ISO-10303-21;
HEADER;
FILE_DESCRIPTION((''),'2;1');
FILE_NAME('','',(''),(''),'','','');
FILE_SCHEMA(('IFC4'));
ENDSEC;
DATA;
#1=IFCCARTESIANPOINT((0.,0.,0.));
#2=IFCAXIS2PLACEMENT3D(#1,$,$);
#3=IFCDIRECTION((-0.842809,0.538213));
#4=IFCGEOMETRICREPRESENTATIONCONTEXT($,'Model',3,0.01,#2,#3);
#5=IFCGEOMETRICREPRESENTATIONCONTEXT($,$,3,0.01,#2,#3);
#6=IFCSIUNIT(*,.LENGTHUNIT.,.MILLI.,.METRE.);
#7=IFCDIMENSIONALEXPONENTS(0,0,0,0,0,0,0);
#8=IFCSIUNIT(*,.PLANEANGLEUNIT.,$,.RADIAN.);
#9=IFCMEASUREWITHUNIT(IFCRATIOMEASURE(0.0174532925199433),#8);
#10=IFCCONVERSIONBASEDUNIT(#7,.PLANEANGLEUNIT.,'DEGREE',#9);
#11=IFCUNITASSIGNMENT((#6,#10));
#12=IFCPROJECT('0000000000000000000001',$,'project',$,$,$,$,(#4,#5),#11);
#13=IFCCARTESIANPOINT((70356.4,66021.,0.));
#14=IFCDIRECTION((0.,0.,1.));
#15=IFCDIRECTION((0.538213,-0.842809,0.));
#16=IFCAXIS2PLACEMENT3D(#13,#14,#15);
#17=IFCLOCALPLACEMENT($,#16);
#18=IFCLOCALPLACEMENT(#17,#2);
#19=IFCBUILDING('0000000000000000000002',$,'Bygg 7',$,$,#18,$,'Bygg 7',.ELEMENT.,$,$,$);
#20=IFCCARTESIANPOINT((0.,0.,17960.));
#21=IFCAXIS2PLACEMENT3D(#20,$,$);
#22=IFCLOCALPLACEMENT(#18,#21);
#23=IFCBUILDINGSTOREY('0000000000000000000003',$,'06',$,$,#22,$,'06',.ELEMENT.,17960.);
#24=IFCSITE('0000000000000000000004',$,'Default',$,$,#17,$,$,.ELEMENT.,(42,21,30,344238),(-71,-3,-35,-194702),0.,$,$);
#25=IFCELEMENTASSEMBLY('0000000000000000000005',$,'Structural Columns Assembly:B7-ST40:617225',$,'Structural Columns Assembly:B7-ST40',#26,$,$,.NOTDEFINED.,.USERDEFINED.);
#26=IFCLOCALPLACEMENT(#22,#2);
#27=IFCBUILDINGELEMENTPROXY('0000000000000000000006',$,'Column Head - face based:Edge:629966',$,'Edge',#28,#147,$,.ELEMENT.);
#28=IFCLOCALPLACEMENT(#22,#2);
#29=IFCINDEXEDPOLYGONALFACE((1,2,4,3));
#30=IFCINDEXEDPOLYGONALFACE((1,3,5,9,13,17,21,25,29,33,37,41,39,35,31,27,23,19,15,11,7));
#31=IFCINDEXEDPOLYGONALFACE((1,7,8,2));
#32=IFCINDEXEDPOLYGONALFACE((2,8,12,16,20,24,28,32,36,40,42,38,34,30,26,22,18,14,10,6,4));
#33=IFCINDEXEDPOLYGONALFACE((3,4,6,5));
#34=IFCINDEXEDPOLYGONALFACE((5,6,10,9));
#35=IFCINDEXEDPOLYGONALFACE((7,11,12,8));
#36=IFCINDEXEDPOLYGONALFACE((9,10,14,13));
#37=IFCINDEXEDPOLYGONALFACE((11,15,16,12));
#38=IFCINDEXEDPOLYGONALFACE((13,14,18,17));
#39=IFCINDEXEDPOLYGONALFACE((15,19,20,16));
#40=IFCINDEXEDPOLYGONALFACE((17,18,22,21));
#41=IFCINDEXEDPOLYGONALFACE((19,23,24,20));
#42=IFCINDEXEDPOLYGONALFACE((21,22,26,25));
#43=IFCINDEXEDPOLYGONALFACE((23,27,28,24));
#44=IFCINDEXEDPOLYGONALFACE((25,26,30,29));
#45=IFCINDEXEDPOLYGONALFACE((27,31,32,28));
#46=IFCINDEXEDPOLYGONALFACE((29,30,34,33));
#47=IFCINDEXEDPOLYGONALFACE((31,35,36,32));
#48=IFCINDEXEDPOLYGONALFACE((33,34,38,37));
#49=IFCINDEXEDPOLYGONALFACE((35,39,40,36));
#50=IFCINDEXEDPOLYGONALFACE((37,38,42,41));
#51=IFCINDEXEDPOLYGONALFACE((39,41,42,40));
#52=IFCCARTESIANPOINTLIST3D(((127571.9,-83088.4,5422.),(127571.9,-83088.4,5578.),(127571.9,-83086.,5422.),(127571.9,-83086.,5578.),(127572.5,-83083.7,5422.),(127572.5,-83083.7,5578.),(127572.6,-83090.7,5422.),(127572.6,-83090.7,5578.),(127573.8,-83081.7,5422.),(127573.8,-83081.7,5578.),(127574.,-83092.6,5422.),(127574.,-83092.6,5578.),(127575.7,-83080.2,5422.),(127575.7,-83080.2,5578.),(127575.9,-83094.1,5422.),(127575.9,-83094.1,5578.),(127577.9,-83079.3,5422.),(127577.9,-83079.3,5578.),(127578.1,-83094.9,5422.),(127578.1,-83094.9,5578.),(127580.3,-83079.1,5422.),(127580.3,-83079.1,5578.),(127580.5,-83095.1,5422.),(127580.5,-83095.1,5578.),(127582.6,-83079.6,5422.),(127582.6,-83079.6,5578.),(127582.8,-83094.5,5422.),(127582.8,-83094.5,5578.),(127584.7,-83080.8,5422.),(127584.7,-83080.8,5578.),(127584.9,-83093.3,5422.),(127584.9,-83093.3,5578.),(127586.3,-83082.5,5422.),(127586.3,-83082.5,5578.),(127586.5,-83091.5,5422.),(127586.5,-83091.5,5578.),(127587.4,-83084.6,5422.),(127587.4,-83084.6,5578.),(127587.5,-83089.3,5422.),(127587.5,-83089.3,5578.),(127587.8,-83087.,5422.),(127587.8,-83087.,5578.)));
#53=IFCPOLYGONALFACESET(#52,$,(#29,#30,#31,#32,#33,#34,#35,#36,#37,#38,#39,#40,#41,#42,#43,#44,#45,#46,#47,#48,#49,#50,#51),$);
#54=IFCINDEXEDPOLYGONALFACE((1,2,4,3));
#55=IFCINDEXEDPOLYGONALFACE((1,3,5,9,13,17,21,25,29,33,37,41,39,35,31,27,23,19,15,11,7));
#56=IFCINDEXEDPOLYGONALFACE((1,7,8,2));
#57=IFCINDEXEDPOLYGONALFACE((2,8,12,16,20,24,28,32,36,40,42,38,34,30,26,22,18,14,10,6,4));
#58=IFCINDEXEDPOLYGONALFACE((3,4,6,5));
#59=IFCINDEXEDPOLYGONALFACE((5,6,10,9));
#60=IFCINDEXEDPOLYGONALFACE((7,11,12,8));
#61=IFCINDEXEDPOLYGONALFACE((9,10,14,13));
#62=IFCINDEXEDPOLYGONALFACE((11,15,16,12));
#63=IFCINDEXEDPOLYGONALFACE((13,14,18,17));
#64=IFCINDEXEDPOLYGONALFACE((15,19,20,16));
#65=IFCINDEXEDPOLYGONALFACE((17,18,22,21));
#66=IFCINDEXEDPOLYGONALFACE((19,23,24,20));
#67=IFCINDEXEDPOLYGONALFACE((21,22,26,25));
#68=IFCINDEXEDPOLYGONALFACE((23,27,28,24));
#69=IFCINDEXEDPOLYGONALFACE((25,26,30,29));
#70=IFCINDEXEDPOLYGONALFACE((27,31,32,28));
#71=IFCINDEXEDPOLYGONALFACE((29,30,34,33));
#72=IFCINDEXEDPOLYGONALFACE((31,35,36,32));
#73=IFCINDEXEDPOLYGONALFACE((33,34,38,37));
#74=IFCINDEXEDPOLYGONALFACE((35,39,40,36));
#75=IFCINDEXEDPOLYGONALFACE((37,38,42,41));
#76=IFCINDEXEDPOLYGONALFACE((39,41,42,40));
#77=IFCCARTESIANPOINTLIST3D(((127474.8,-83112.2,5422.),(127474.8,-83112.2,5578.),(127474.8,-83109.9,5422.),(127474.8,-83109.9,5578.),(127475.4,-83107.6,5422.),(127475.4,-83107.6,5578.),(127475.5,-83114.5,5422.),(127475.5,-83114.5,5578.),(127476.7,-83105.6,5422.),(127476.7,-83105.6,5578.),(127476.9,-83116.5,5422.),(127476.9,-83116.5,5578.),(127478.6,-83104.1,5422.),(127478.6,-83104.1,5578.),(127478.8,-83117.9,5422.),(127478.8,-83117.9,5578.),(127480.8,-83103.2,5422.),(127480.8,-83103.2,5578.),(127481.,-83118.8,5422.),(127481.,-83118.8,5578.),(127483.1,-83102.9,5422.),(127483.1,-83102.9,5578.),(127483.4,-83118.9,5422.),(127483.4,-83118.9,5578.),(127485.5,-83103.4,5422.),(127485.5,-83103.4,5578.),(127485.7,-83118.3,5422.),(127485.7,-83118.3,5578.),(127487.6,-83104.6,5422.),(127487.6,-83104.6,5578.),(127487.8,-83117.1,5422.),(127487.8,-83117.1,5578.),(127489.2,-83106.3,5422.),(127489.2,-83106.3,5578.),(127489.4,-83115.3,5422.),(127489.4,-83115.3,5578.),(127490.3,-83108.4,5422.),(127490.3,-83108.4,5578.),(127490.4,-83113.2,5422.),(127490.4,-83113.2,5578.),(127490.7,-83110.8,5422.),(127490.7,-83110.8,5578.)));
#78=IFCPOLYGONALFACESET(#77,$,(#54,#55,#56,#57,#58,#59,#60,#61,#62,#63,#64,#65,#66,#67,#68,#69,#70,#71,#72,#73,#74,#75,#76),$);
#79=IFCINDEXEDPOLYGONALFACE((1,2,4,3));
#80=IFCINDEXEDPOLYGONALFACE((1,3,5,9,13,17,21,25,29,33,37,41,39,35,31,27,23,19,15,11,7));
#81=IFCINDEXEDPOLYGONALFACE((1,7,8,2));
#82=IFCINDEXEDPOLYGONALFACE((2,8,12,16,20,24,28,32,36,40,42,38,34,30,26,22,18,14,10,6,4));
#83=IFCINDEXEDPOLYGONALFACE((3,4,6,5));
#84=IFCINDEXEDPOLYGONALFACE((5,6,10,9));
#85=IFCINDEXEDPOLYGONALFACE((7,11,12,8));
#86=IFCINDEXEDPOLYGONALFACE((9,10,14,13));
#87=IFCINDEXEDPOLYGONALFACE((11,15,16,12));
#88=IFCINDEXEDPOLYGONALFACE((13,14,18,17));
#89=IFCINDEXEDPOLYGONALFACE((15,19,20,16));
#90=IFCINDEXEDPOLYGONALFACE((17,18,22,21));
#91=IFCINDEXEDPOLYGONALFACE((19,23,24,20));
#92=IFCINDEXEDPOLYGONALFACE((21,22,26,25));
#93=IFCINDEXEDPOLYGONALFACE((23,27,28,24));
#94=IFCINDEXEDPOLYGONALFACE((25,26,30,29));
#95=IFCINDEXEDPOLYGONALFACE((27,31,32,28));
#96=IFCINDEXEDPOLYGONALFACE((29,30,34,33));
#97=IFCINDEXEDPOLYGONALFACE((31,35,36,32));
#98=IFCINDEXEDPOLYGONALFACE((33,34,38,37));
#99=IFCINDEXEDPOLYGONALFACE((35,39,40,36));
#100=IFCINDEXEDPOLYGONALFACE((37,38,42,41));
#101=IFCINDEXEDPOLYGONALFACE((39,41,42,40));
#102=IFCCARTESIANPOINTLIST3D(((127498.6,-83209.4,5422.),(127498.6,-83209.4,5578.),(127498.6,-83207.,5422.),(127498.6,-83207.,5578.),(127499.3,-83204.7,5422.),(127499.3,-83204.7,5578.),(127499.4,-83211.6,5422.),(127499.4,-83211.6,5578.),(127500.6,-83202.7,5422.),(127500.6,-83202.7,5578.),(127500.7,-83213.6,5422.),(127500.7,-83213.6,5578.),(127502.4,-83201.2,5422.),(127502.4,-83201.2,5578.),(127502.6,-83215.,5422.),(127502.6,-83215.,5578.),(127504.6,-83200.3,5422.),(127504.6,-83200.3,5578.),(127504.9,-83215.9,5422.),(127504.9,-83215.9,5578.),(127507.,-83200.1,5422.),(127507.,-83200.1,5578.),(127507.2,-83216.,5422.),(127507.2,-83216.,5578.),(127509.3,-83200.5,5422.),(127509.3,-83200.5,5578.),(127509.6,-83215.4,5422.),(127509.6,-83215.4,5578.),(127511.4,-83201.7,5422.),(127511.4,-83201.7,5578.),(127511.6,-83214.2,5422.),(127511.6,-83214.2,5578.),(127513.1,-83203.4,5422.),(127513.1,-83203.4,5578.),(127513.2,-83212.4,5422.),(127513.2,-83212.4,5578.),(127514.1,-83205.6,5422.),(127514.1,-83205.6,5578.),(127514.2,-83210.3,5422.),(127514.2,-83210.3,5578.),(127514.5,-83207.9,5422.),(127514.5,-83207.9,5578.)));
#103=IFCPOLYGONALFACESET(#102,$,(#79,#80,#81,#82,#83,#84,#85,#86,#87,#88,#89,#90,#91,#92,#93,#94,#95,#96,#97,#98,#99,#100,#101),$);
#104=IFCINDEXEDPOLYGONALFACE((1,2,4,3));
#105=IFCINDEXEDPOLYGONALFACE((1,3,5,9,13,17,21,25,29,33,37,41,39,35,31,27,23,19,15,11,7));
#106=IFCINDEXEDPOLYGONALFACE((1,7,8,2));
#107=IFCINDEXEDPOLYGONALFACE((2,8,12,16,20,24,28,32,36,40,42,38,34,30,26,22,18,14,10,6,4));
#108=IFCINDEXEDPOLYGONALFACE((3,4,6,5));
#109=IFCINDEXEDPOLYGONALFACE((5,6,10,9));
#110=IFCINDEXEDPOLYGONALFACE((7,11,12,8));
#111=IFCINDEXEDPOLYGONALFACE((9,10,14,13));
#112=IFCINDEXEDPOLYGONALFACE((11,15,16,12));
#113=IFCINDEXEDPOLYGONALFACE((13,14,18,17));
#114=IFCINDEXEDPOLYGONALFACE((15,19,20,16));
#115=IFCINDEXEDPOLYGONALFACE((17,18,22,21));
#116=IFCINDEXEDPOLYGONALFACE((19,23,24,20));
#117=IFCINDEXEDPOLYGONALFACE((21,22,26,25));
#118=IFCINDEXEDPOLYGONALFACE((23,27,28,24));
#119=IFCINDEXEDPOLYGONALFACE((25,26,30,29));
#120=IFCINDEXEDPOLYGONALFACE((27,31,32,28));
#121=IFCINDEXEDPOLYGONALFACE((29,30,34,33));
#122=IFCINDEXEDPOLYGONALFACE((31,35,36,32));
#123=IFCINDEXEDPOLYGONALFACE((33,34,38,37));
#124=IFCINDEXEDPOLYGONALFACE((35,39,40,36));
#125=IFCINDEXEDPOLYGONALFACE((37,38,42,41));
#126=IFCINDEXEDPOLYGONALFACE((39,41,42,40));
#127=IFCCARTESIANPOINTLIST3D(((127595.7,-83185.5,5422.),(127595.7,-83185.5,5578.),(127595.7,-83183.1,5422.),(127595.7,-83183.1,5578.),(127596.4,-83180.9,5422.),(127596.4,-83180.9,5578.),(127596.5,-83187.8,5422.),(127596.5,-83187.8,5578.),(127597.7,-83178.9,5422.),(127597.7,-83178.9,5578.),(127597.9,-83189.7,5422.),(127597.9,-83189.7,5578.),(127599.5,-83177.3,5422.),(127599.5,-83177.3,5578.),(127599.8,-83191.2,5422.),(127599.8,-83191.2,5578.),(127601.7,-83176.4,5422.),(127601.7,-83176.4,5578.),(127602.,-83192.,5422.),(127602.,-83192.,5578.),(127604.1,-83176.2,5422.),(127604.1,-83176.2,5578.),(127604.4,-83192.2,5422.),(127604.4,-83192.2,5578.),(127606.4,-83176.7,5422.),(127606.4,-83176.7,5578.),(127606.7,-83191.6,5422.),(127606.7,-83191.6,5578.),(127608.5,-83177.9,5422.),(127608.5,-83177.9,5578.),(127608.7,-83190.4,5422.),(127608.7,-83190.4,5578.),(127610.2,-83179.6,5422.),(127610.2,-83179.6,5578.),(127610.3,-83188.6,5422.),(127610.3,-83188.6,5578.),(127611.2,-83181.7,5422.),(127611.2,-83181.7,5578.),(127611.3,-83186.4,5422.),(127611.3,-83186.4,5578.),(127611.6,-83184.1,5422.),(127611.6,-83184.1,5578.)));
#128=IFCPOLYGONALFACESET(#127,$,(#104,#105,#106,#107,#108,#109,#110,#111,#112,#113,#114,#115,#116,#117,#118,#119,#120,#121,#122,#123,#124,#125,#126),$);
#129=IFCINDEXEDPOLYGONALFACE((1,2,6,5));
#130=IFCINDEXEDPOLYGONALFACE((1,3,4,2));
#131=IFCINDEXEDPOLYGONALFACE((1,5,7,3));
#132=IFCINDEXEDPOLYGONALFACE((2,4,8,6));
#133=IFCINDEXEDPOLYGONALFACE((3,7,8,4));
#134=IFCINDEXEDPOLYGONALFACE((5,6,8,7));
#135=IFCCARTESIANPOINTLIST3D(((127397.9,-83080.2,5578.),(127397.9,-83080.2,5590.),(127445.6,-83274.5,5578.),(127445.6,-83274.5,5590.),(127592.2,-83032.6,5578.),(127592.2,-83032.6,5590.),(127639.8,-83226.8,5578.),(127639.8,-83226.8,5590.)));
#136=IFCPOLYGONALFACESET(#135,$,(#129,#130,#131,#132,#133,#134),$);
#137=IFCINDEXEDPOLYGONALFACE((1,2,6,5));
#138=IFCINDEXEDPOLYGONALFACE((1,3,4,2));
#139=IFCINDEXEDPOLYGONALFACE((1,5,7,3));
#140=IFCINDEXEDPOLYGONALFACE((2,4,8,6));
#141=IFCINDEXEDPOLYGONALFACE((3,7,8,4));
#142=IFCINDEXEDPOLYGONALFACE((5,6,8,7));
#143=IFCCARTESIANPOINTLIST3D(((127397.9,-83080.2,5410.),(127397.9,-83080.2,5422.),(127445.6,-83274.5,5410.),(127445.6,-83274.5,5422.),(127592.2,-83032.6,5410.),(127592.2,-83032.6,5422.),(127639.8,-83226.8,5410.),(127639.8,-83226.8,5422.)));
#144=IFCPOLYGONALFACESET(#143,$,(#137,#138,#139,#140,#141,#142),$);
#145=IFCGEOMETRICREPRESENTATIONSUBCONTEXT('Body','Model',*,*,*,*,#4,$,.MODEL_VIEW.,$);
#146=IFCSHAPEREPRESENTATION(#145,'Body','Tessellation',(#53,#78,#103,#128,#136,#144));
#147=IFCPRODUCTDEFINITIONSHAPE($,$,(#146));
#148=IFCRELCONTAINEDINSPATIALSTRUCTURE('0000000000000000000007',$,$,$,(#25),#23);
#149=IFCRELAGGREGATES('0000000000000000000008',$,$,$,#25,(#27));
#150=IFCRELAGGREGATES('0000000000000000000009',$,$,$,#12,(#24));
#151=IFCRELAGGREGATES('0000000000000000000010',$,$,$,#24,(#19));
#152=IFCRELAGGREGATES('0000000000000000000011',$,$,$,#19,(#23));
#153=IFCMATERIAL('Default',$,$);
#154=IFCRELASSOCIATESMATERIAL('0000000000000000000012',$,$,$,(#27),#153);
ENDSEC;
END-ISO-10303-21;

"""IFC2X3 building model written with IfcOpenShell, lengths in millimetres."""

from ifc_helpers import new_model, entity, si_unit, converted_unit, direction, frame, frame_2d, origin, origin_2d_with_axis, place, context, subcontext, project, spatial, rectangle, circle, extrude, source, transform, mapped, material, element, aggregate, save


model = new_model("IFC2X3")

# Units and contexts
model_context = context("Model", 3, precision=0.01, world=origin(), true_north=direction((-0.842809, 0.538213)))
context_of_model = context(None, 3, precision=0.01, world=origin(), true_north=direction((-0.842809, 0.538213)))
body_context = subcontext(model_context, "Body", "Model", "MODEL_VIEW")
ifc_project = project(units=[si_unit("LENGTHUNIT", "METRE", prefix="MILLI"), converted_unit("PLANEANGLEUNIT", "DEGREE", entity("IfcRatioMeasure", 0.0174532925199433), si_unit("PLANEANGLEUNIT", "RADIAN"), dimensions=[0, 0, 0, 0, 0, 0, 0])], contexts=[model_context, context_of_model])

# Site, building, storey
site_placement = place(None, frame((70356.4, 66021.0, 0.0), z_axis=(0.0, 0.0, 1.0), x_axis=(0.538213, -0.842809, 0.0)))
site = spatial("IfcSite", under=ifc_project, at=site_placement, Name="Default", CompositionType="ELEMENT", RefLatitude=(42, 21, 30, 344238), RefLongitude=(-71, -3, -35, -194702), RefElevation=0.0)
building_placement = place(site_placement, origin())
building = spatial("IfcBuilding", under=site, at=building_placement, Name="Bygg 7", LongName="Bygg 7", CompositionType="ELEMENT")
storey_placement = place(building_placement, frame((0.0, 0.0, 17960.0)))
storey = spatial("IfcBuildingStorey", under=building, at=storey_placement, Name="06", LongName="06", CompositionType="ELEMENT", Elevation=17960.0)

# Element assembly
assembly_1_placement = place(storey_placement, origin())
assembly_1 = element("IfcElementAssembly", 1, at=assembly_1_placement, inside=storey, Name="Structural Columns Assembly:B7-ST40:617225", ObjectType="Structural Columns Assembly:B7-ST40", AssemblyPlace="NOTDEFINED", PredefinedType="USERDEFINED")

# Building element proxy
ifc_material_1 = material(Name="Default")
shared_shape_1 = source(origin(), body_context, "Body", "SweptSolid", [
    extrude(circle(Radius=8.0, at=frame_2d((0.0, 0.0), x_axis=(1.0, 0.0))), frame((50.0, -135.0, 12.0)), (0.0, 0.0, 1.0), 156.0),
    extrude(circle(Radius=8.0, at=frame_2d((0.0, 0.0), x_axis=(1.0, 0.0))), frame((50.0, -35.0, 12.0)), (0.0, 0.0, 1.0), 156.0),
    extrude(circle(Radius=8.0, at=frame_2d((0.0, 0.0), x_axis=(1.0, 0.0))), frame((-50.0, -35.0, 12.0)), (0.0, 0.0, 1.0), 156.0),
    extrude(circle(Radius=8.0, at=frame_2d((0.0, 0.0), x_axis=(1.0, 0.0))), frame((-50.0, -135.0, 12.0)), (0.0, 0.0, 1.0), 156.0),
    extrude(rectangle(XDim=200.0, YDim=200.0, at=origin_2d_with_axis()), frame((0.0, -60.0, 168.0), z_axis=(0.0, 0.0, 1.0), x_axis=(-1.0, 0.0, 0.0)), (0.0, 0.0, 1.0), 12.0),
    extrude(rectangle(XDim=200.0, YDim=200.0, at=origin_2d_with_axis()), frame((0.0, -60.0, 0.0), z_axis=(0.0, 0.0, 1.0), x_axis=(0.0, 1.0, 0.0)), (0.0, 0.0, 1.0), 12.0),
])
proxy_1_placement = place(assembly_1_placement, frame((127460.6, -83167.8, 5410.0), z_axis=(0.0, 0.0, 1.0), x_axis=(-0.238381, 0.971172, 0.0)))
proxy_1 = element("IfcBuildingElementProxy", 2, at=proxy_1_placement, material=ifc_material_1, Name="Column Head - face based:Edge:629966", ObjectType="Edge", CompositionType="ELEMENT", context=body_context, shape_type="MappedRepresentation", body=[
    mapped(shared_shape_1, transform((0.0, 0.0, 0.0), scale=1.0)),
])
aggregate(assembly_1, [proxy_1])

save(model, "model.ifc")
